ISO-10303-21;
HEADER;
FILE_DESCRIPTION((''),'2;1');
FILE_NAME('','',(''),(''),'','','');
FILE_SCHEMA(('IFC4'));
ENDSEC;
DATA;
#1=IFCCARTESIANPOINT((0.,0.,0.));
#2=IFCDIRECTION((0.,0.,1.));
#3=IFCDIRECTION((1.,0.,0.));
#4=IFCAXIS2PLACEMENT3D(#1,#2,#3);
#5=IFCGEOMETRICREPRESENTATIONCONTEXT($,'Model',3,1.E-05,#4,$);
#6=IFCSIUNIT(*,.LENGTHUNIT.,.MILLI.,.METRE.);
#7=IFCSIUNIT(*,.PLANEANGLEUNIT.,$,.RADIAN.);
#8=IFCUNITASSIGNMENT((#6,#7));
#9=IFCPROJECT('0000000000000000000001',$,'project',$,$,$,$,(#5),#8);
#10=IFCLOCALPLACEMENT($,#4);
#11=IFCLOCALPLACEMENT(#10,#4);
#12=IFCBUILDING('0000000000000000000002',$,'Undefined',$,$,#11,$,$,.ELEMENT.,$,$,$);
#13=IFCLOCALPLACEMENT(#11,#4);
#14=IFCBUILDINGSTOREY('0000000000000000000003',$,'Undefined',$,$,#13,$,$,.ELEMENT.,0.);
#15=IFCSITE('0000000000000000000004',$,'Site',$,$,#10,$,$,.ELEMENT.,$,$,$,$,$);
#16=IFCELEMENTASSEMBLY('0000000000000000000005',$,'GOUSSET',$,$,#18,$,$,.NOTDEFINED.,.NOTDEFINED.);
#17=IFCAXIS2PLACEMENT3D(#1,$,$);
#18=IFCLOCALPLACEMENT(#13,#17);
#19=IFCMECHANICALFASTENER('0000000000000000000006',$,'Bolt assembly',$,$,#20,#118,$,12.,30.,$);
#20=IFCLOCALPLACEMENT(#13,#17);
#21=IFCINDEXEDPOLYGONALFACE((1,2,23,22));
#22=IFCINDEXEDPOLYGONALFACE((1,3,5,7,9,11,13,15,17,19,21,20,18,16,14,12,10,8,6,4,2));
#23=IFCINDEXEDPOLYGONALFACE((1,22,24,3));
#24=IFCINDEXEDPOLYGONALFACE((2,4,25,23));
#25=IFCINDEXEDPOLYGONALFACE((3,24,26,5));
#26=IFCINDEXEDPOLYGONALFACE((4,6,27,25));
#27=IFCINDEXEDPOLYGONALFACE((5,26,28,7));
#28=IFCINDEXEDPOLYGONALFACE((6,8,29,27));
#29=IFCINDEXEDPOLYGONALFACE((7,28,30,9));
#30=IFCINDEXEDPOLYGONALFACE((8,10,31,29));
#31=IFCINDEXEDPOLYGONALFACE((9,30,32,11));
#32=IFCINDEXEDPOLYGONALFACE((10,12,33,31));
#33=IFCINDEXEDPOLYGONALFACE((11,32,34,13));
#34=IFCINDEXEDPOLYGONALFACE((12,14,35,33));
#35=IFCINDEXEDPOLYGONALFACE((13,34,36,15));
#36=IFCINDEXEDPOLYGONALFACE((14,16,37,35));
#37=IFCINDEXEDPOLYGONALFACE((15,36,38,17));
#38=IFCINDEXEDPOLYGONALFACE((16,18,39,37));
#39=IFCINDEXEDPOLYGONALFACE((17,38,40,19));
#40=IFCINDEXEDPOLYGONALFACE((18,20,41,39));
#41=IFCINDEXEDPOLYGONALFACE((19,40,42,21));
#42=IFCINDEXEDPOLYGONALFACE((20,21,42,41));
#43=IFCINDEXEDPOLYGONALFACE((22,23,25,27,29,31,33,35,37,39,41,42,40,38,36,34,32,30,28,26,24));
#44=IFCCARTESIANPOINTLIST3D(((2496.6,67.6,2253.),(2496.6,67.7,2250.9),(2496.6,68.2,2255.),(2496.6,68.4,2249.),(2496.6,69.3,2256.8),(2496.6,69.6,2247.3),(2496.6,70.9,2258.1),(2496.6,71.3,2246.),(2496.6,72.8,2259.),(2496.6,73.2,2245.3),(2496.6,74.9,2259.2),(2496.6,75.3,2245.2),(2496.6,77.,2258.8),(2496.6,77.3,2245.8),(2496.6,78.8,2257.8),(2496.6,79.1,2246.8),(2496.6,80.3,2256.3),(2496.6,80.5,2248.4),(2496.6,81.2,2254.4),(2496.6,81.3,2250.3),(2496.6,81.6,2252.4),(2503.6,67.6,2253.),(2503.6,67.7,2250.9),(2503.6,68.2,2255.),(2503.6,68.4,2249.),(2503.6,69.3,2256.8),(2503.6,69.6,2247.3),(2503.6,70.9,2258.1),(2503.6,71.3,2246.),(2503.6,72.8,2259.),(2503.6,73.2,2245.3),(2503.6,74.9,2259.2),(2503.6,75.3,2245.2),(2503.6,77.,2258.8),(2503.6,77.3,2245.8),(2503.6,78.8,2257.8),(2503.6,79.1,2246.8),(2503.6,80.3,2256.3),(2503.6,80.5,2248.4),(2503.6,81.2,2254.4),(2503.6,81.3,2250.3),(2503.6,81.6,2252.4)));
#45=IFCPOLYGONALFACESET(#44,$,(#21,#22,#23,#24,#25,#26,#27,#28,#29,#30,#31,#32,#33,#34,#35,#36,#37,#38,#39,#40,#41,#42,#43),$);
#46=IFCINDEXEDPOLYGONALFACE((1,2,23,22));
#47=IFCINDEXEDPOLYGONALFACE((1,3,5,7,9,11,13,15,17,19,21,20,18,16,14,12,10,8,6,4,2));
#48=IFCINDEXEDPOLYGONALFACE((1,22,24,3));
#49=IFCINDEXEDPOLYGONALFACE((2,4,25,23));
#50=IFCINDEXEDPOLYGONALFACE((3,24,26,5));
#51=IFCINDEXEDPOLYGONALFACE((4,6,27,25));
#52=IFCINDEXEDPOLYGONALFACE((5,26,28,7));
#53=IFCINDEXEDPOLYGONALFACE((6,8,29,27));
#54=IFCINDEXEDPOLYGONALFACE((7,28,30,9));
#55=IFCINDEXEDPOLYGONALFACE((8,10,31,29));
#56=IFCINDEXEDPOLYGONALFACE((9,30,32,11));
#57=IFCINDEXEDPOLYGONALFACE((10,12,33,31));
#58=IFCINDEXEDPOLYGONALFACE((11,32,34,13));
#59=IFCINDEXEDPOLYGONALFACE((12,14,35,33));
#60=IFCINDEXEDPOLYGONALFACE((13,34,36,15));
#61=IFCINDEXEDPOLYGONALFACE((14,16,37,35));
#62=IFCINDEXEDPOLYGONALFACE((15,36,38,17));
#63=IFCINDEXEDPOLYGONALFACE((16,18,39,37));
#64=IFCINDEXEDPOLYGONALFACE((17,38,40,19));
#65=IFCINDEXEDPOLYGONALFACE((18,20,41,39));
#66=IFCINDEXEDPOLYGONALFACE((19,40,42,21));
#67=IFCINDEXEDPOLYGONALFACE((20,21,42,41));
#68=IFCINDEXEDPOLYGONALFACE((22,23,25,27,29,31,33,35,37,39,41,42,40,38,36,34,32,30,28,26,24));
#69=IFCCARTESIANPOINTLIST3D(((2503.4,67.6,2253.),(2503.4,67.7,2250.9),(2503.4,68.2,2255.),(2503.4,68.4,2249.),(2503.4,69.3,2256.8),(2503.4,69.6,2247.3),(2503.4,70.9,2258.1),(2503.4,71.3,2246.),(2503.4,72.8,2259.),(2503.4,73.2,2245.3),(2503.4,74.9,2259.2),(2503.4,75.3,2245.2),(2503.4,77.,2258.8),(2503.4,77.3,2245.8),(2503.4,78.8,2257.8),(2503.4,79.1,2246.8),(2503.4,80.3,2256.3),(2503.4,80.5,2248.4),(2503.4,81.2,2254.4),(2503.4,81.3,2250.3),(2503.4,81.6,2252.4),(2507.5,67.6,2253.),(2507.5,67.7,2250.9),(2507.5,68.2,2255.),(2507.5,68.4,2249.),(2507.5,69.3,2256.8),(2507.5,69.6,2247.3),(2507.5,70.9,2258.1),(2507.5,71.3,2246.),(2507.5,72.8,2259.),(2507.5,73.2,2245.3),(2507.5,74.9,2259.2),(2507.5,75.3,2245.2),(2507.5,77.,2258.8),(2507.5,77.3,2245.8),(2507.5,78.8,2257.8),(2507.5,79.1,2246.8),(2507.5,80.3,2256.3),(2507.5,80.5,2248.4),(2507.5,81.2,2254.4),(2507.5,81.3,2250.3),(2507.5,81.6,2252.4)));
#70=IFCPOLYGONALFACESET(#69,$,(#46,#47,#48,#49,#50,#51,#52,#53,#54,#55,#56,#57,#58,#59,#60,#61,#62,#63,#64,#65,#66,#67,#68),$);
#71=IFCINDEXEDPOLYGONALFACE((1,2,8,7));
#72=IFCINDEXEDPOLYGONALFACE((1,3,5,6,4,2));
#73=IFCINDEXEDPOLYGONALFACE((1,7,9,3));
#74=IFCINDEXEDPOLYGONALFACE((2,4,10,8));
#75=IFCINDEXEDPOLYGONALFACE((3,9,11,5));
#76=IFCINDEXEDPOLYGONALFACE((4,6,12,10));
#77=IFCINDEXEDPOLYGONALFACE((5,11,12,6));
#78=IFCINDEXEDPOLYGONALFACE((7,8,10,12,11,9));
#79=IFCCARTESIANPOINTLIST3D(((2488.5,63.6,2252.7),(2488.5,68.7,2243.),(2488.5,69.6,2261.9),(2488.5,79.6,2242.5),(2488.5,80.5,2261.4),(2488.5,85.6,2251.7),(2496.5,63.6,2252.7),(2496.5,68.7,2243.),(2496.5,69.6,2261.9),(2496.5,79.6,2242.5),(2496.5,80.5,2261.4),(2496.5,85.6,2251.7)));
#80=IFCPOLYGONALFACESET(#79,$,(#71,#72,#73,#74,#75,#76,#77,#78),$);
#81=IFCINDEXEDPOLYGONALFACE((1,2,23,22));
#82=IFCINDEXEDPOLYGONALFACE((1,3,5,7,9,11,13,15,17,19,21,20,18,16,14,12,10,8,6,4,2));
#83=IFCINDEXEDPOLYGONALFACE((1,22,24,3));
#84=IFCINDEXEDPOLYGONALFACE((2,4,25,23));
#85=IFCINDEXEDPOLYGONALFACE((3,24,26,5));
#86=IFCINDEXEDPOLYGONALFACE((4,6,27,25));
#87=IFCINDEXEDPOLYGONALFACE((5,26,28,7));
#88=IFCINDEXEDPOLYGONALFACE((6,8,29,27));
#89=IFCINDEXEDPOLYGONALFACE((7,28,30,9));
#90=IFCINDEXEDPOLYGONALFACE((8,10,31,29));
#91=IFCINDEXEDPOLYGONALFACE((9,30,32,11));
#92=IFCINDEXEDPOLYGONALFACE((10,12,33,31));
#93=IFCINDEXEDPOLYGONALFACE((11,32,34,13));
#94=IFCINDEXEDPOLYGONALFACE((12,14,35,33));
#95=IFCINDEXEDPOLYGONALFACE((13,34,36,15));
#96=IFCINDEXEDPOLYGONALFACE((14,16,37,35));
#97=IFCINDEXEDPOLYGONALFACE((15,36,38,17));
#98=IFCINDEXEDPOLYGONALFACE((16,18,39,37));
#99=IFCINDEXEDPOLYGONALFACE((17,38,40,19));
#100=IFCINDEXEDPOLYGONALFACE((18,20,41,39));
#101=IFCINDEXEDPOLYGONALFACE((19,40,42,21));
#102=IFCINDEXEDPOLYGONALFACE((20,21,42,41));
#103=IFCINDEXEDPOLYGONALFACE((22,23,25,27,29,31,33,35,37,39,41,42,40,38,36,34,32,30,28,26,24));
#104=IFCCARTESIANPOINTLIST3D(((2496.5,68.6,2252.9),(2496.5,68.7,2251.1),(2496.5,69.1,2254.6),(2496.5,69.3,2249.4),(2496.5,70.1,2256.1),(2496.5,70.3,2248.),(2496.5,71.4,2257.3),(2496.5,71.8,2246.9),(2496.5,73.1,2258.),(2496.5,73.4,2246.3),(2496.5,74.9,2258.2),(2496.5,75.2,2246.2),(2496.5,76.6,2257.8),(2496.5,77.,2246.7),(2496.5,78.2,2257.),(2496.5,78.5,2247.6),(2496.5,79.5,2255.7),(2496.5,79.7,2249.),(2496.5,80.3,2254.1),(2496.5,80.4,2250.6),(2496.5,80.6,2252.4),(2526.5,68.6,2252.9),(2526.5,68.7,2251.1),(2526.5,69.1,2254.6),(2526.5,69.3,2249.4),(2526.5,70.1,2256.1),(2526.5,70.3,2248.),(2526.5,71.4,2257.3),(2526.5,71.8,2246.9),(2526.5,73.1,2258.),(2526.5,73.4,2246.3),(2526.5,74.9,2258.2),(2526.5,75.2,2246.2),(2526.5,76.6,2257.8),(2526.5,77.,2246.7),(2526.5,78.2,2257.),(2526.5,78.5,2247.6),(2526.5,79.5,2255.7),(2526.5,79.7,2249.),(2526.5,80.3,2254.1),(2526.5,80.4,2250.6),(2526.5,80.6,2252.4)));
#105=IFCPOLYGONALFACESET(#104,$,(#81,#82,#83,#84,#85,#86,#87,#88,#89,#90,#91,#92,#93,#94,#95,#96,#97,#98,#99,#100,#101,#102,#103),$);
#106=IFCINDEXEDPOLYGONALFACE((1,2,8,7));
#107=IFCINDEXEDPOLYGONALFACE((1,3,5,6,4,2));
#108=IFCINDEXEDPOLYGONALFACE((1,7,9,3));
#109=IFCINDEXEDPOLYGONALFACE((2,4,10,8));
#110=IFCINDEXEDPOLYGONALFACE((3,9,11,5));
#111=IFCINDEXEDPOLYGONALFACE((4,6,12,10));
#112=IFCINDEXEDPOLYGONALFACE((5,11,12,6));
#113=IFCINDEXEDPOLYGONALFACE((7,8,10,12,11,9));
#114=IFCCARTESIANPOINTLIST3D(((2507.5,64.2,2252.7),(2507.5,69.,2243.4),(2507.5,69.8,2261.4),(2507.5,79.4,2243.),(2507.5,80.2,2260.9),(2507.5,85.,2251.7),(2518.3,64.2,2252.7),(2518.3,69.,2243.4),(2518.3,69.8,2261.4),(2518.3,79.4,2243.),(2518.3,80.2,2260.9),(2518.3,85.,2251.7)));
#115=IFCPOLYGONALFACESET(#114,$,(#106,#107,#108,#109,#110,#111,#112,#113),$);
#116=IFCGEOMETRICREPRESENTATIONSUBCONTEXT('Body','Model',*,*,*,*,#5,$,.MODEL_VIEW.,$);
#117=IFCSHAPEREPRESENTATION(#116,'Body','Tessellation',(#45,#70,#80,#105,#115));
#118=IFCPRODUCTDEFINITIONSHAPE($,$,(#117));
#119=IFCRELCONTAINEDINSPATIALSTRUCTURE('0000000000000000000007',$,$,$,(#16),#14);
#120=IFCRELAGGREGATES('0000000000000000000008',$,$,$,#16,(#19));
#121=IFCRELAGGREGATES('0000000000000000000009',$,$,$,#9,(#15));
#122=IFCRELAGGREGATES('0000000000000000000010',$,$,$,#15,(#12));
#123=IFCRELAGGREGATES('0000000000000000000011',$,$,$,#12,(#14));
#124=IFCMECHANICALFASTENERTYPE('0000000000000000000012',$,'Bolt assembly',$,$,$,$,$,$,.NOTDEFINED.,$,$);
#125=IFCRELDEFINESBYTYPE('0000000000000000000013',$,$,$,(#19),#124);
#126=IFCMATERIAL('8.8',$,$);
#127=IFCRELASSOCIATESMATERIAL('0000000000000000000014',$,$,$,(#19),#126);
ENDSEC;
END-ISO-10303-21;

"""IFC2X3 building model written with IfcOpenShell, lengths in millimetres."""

from ifc_helpers import new_model, si_unit, frame, origin_with_axes, origin_2d_with_axis, place, context, subcontext, project, spatial, polyline, circle, outline, extrude, source, transform, mapped, material, type_object, element, aggregate, save


model = new_model("IFC2X3")

# Units and contexts
model_context = context("Model", 3, precision=1e-05, world=origin_with_axes())
body_context = subcontext(model_context, "Body", "Model", "MODEL_VIEW")
ifc_project = project(units=[si_unit("LENGTHUNIT", "METRE", prefix="MILLI"), si_unit("PLANEANGLEUNIT", "RADIAN")], contexts=[model_context])

# Site, building, storey
site_placement = place(None, origin_with_axes())
site = spatial("IfcSite", under=ifc_project, at=site_placement, Name="Site", CompositionType="ELEMENT")
building_placement = place(site_placement, origin_with_axes())
building = spatial("IfcBuilding", under=site, at=building_placement, Name="Undefined", CompositionType="ELEMENT")
storey_placement = place(building_placement, origin_with_axes())
storey = spatial("IfcBuildingStorey", under=building, at=storey_placement, Name="Undefined", CompositionType="ELEMENT", Elevation=0.0)

# Element assembly
assembly_1_placement = place(storey_placement, origin_with_axes())
assembly_1 = element("IfcElementAssembly", 1, at=assembly_1_placement, inside=storey, Name="GOUSSET", AssemblyPlace="NOTDEFINED", PredefinedType="NOTDEFINED")

# Shared definitions
ifc_material_1 = material(Name="8.8")
mechanical_fastener_type = type_object("IfcMechanicalFastenerType", Name="Bolt assembly")

# Mechanical fastener
shared_shape_1 = source(origin_with_axes(), body_context, "Body", "SweptSolid", [
    extrude(circle(Radius=7.0, at=origin_2d_with_axis()), frame((0.0, -22.9, 0.0), z_axis=(0.0, 1.0, 0.0), x_axis=(1.0, 0.0, 0.0)), (0.0, 0.0, 1.0), 7.0),
    extrude(circle(Radius=7.0, at=origin_2d_with_axis()), frame((0.0, -16.1, 0.0), z_axis=(0.0, 1.0, 0.0), x_axis=(1.0, 0.0, 0.0)), (0.0, 0.0, 1.0), 4.1),
    extrude(outline(polyline([(9.5, -5.5), (9.5, 5.5), (0.0, 11.0), (-9.5, 5.5), (-9.5, -5.5), (0.0, -11.0), (9.5, -5.5)])), frame((0.0, -31.0, 0.0), z_axis=(0.0, 1.0, 0.0), x_axis=(1.0, 0.0, 0.0)), (0.0, 0.0, 1.0), 8.0),
    extrude(circle(Radius=6.0, at=origin_2d_with_axis()), frame((0.0, -23.0, 0.0), z_axis=(0.0, 1.0, 0.0), x_axis=(1.0, 0.0, 0.0)), (0.0, 0.0, 1.0), 30.0),
    extrude(outline(polyline([(9.0, -5.2), (9.0, 5.2), (0.0, 10.4), (-9.0, 5.2), (-9.0, -5.2), (0.0, -10.4), (9.0, -5.2)])), frame((0.0, -12.0, 0.0), z_axis=(0.0, 1.0, 0.0), x_axis=(1.0, 0.0, 0.0)), (0.0, 0.0, 1.0), 10.8),
])
mechanical_fastener_1_placement = place(assembly_1_placement, frame((2519.5, 74.6, 2252.2), z_axis=(0.0, -0.459948, 0.887946), x_axis=(0.0, -0.887946, -0.459948)))
mechanical_fastener_1 = element("IfcMechanicalFastener", 2, at=mechanical_fastener_1_placement, type_object=mechanical_fastener_type, material=ifc_material_1, Name="Bolt assembly", NominalDiameter=12.0, NominalLength=30.0, context=body_context, shape_type="MappedRepresentation", body=[
    mapped(shared_shape_1, transform((0.0, 0.0, 0.0))),
])
aggregate(assembly_1, [mechanical_fastener_1])

save(model, "model.ifc")
